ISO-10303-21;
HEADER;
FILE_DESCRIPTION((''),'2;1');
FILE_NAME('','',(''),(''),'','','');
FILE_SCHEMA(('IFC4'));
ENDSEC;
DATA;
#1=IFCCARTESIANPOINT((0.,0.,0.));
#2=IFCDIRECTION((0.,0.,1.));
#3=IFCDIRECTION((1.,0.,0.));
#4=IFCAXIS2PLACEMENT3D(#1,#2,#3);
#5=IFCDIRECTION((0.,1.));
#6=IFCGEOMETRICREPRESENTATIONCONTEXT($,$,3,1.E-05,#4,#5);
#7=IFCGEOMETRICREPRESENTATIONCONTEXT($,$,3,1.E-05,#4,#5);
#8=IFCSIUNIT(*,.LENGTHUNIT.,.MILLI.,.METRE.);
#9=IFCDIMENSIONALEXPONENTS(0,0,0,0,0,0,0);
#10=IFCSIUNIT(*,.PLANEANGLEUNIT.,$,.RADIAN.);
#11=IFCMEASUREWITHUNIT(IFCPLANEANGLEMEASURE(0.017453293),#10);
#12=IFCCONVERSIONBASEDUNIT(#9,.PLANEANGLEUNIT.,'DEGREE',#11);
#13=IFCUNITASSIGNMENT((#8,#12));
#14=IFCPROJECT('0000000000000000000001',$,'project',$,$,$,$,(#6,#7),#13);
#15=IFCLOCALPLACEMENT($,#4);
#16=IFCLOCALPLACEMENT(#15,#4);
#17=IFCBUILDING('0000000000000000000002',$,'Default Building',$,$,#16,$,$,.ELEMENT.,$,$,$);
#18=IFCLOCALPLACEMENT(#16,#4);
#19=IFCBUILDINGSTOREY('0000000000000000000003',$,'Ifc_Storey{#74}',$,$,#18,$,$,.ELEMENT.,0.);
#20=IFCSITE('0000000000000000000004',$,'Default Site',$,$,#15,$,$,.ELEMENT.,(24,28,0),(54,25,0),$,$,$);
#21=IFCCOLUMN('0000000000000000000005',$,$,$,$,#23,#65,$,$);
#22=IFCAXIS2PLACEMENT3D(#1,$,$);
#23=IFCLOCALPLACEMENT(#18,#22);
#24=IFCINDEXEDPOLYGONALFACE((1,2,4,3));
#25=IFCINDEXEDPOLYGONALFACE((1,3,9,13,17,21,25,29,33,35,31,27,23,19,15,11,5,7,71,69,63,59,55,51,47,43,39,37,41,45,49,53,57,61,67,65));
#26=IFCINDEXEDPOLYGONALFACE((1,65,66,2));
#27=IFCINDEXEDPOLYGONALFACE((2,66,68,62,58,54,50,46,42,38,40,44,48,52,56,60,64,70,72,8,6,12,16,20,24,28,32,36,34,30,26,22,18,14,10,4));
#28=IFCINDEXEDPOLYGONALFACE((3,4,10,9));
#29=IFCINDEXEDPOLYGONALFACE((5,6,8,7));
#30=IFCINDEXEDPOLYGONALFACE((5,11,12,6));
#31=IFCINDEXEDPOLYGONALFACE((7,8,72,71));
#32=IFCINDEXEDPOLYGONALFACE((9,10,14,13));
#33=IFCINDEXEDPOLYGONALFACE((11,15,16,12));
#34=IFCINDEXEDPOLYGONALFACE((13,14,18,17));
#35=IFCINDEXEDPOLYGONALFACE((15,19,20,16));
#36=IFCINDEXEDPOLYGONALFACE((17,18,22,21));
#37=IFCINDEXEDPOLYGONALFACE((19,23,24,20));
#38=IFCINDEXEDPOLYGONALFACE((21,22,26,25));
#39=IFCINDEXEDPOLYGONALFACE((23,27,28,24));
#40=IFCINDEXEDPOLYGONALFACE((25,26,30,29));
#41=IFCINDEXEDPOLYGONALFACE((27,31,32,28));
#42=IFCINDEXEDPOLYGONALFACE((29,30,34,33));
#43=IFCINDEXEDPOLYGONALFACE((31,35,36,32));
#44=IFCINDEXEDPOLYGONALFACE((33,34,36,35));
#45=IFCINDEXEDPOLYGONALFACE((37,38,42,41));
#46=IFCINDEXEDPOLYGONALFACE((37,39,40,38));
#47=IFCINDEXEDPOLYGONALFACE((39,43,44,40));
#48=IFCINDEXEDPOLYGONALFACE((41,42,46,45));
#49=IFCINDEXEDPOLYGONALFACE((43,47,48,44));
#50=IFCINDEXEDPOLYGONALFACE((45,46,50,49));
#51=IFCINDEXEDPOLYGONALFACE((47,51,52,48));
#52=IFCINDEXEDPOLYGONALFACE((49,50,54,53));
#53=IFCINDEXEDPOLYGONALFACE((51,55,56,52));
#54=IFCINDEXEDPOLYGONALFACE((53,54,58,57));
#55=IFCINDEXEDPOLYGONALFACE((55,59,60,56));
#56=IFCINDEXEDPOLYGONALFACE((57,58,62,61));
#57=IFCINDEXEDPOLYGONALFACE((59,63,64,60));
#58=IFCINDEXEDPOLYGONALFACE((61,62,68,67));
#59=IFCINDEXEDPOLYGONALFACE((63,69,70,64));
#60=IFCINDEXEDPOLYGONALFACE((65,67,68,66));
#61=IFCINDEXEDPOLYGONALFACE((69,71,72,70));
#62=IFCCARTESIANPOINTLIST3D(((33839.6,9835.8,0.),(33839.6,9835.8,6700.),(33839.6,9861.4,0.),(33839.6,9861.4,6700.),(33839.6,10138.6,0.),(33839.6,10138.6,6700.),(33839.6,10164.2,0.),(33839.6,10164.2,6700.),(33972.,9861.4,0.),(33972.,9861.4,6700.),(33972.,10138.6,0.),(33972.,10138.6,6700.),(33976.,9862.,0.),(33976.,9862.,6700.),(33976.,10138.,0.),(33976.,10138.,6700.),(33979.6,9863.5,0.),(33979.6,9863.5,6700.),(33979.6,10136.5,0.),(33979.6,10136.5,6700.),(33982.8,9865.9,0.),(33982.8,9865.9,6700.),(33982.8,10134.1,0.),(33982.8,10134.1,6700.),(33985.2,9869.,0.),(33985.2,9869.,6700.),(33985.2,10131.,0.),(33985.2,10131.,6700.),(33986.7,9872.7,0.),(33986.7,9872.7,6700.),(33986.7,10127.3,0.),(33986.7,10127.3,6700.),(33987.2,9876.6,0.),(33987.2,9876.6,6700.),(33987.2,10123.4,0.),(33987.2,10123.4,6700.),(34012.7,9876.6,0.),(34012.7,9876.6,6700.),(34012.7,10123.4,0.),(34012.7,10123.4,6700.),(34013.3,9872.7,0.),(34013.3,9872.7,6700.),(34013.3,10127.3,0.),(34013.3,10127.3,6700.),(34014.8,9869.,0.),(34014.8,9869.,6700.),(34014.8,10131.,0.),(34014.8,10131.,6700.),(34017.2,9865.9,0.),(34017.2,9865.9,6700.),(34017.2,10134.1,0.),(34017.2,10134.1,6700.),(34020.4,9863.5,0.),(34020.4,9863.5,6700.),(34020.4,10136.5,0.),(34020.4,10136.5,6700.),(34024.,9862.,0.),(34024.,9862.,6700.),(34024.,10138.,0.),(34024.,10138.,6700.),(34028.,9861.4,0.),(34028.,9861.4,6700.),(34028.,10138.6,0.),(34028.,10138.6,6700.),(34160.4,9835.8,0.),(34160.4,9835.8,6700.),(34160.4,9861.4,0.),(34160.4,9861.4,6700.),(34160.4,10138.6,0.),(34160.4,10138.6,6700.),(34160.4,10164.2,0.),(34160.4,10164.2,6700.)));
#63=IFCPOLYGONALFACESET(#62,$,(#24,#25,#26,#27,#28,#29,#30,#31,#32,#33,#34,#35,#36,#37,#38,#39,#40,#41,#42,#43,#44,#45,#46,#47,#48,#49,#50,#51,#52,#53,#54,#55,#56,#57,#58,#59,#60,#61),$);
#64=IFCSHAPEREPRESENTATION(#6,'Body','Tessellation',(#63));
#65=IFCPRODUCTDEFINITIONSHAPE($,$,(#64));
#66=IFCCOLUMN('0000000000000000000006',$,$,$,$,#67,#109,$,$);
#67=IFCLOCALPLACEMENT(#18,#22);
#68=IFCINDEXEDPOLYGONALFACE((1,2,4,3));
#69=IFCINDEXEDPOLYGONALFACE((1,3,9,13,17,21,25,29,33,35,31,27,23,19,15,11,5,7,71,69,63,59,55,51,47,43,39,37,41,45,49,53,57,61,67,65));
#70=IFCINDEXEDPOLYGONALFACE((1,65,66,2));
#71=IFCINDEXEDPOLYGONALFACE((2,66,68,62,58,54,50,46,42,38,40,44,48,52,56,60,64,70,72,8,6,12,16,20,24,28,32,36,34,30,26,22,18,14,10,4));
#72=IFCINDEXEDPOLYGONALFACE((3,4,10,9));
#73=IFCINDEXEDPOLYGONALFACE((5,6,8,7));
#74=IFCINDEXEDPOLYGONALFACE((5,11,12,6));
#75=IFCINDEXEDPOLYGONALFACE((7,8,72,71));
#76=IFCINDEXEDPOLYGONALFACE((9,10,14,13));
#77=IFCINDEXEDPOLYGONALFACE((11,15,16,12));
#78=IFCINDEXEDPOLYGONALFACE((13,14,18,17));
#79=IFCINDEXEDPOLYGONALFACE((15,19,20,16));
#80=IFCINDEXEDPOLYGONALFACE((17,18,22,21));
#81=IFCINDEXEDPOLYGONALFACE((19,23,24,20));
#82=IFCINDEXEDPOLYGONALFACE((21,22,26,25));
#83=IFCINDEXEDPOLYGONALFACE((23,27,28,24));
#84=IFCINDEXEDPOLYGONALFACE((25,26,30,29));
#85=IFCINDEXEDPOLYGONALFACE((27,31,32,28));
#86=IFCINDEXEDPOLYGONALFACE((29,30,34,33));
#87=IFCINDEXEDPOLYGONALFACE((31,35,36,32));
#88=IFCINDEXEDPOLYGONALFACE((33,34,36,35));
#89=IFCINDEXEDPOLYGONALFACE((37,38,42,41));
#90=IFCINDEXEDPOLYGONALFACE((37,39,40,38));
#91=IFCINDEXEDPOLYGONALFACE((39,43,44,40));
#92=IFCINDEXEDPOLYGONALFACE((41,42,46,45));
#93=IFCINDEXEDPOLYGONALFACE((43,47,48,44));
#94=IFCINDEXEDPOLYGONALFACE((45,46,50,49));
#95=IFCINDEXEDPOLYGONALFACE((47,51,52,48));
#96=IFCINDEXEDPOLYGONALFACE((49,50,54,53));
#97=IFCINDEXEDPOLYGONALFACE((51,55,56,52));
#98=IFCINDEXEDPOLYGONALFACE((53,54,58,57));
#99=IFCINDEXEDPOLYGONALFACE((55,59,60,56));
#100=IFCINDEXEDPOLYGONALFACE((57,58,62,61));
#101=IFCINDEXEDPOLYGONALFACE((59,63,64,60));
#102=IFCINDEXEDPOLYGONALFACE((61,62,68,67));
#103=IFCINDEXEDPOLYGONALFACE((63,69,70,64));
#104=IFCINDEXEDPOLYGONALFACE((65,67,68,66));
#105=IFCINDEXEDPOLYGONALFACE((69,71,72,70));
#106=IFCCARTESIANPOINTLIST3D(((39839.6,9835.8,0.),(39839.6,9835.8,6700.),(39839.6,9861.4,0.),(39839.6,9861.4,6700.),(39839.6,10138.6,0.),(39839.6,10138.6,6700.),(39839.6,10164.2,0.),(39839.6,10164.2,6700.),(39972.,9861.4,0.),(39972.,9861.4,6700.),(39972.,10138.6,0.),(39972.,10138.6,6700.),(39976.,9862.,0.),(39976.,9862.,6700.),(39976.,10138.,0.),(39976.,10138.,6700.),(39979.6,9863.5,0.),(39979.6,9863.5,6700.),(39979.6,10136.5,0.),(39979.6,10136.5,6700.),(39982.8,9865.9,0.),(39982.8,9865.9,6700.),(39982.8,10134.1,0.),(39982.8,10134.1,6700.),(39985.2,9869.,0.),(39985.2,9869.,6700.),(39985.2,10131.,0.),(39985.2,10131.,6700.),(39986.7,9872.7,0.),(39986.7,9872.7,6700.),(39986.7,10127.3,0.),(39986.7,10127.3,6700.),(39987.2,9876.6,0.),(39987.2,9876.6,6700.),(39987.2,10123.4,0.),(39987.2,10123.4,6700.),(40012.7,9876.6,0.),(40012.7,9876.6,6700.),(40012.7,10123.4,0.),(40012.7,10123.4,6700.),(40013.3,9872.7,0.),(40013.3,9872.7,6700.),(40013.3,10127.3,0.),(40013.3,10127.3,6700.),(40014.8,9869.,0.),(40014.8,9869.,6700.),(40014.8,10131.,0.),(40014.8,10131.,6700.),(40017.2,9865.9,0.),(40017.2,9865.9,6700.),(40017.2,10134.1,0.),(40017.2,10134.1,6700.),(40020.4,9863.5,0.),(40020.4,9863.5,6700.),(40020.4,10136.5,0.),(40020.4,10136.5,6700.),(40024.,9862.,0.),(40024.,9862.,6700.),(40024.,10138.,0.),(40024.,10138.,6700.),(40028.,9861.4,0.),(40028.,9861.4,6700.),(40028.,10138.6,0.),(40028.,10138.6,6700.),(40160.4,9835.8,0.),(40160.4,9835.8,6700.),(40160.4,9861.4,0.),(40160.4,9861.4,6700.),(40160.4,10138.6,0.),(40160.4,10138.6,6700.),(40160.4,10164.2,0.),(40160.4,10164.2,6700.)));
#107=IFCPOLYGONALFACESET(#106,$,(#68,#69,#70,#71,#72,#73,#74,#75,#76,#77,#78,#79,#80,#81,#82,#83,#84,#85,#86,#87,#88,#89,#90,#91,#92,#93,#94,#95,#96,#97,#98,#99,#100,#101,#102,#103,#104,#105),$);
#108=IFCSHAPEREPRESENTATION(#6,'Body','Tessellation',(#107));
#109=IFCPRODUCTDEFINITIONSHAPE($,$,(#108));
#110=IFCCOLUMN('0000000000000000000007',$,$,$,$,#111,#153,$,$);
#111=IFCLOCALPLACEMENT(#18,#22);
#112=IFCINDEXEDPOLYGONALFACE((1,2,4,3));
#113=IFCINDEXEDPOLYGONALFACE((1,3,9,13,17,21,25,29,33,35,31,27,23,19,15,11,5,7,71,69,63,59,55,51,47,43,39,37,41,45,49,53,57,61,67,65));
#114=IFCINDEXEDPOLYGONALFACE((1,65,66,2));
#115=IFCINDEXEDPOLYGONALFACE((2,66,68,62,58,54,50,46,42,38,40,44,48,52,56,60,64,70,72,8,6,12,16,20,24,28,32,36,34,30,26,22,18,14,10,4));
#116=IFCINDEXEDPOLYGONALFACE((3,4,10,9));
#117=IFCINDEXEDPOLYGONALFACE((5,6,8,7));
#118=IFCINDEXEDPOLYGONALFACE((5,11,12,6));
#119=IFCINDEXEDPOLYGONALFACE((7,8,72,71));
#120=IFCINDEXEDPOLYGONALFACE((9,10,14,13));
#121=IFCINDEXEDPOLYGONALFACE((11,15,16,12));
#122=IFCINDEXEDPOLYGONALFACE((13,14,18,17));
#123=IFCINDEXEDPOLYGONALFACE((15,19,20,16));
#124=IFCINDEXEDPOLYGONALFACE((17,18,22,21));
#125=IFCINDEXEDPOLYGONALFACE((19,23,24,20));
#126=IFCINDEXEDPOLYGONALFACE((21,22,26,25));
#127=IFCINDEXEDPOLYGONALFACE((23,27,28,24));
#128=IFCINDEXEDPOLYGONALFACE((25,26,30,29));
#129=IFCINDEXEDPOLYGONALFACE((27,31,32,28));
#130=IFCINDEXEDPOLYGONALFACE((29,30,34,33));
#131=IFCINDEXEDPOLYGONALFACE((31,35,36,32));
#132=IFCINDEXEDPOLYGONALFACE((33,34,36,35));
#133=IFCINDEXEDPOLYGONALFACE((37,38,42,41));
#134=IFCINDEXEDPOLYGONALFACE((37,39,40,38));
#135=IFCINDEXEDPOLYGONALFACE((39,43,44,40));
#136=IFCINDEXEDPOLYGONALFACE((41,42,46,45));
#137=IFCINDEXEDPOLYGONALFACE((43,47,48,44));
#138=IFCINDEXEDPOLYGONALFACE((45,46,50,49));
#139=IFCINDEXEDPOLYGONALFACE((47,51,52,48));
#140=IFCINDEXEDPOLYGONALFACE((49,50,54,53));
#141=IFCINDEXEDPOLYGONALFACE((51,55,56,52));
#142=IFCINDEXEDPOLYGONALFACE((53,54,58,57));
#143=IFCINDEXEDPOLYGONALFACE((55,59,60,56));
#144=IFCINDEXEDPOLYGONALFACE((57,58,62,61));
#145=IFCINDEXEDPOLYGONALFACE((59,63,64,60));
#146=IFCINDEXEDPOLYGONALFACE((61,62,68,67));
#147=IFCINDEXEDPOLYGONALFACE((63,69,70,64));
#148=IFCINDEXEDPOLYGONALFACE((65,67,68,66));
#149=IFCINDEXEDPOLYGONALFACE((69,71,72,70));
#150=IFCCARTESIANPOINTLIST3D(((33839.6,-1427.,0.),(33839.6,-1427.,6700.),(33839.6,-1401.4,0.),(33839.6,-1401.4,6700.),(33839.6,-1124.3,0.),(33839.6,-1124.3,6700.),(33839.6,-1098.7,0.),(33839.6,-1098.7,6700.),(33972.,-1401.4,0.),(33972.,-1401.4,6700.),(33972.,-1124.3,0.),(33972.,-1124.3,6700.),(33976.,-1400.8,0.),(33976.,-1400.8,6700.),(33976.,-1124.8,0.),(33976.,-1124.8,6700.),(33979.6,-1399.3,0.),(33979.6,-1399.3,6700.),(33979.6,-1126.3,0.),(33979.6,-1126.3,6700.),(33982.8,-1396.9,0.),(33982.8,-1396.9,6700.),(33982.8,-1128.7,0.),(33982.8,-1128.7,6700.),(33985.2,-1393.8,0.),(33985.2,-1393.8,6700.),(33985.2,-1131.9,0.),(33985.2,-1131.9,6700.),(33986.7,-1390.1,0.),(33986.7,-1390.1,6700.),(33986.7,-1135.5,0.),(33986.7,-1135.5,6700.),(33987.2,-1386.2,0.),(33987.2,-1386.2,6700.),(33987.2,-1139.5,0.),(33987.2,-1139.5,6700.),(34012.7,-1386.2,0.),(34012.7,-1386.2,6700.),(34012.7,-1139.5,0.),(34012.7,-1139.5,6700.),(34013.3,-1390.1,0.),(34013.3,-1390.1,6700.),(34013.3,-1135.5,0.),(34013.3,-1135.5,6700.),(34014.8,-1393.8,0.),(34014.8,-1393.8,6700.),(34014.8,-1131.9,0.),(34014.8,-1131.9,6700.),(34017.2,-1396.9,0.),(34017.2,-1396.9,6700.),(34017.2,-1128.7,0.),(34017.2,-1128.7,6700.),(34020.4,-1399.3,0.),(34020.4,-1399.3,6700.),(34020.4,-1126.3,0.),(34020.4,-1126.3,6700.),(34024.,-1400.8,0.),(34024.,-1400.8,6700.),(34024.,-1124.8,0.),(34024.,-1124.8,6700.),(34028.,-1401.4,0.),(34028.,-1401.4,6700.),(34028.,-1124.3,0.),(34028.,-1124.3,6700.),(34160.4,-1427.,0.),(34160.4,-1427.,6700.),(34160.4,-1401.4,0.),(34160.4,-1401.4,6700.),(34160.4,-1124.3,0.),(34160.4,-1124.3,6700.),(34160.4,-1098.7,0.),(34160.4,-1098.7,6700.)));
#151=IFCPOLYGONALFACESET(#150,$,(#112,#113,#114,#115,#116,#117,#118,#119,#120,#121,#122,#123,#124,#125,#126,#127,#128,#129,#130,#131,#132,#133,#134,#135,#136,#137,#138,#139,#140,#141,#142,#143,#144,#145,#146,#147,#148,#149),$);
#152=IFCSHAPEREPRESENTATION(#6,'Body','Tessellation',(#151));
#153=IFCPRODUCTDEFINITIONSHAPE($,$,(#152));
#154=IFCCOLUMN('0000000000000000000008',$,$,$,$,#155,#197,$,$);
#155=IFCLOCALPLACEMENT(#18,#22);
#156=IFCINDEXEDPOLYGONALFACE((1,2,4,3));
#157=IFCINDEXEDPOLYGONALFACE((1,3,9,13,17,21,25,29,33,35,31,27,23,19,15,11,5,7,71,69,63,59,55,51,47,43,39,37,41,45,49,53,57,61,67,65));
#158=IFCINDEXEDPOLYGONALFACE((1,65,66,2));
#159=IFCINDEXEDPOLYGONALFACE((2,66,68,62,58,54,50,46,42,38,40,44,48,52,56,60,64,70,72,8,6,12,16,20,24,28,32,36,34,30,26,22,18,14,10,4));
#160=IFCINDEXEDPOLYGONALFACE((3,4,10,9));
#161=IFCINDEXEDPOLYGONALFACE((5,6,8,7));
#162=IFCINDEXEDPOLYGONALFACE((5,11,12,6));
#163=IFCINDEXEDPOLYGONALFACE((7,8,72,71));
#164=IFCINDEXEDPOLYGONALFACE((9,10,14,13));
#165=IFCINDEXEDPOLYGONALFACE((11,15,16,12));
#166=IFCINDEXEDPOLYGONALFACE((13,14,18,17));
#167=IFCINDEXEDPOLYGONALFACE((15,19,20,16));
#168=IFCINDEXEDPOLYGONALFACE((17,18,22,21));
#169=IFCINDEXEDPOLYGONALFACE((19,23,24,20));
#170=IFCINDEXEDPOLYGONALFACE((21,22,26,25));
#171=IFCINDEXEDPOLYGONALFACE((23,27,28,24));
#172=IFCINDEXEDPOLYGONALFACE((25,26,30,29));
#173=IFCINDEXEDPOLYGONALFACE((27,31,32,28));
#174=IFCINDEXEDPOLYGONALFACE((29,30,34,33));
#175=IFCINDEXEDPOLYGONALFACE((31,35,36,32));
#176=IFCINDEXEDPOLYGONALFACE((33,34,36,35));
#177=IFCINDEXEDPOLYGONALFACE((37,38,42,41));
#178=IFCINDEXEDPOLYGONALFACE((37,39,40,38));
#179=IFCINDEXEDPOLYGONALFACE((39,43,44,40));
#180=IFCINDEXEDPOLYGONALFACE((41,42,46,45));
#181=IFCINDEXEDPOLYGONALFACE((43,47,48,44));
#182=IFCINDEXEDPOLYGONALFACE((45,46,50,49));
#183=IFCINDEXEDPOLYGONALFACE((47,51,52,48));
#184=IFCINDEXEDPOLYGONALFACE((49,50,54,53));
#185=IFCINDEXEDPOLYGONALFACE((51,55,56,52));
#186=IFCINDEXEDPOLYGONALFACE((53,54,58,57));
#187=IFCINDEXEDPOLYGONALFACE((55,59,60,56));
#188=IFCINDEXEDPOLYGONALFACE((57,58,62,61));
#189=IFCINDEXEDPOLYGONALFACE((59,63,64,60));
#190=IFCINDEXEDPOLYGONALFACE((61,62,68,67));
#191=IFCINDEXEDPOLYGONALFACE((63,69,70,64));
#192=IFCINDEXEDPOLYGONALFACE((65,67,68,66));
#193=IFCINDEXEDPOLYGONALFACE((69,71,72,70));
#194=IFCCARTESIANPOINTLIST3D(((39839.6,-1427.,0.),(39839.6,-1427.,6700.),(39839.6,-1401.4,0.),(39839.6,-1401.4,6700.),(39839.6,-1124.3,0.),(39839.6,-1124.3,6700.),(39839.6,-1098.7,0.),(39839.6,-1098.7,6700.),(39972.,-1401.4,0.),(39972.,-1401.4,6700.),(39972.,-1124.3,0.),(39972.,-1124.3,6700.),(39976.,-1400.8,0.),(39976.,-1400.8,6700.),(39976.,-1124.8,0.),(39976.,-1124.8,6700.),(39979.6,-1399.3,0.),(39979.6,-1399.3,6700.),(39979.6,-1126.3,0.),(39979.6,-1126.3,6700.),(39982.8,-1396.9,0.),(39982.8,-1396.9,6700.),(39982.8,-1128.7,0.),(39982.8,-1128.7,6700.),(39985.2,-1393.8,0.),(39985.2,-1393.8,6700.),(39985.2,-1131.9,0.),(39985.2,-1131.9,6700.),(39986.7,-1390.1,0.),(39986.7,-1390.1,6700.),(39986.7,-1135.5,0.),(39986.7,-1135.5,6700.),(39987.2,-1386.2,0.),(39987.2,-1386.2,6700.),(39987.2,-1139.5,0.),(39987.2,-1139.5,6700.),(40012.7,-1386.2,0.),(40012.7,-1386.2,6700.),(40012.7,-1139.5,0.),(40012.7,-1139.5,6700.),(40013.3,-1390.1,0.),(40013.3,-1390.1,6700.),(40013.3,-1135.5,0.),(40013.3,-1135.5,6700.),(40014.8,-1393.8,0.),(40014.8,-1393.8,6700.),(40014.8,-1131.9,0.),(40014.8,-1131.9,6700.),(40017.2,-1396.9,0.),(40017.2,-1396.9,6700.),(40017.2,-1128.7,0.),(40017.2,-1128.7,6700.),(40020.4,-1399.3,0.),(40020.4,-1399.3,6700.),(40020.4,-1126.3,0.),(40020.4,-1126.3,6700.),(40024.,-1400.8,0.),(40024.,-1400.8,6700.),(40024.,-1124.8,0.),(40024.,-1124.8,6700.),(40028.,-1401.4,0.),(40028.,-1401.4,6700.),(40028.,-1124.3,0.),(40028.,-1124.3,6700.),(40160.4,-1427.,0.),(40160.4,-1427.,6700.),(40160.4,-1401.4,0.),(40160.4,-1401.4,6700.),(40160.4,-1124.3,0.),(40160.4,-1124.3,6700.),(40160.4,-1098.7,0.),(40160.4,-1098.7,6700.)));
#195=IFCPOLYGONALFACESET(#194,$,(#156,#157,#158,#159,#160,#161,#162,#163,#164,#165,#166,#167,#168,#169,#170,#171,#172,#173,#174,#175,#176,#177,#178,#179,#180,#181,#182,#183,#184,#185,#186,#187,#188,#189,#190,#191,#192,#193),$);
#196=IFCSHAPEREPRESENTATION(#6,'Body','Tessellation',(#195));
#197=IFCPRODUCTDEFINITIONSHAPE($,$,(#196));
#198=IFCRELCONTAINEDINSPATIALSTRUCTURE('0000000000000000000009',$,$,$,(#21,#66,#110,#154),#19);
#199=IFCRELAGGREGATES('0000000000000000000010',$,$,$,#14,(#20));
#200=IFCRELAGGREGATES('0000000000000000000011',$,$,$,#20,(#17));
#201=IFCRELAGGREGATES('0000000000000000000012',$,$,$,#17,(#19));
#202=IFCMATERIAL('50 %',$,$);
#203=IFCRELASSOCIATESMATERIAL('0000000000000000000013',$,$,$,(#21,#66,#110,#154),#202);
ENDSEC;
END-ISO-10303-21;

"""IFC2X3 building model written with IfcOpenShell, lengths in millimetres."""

from ifc_helpers import new_model, entity, si_unit, converted_unit, direction, frame, origin_with_axes, origin_2d_with_axis, place, context, project, spatial, i_section, extrude, material, element, save


model = new_model("IFC2X3")

# Units and contexts
context_of_model_1 = context(None, 3, precision=1e-05, world=origin_with_axes(), true_north=direction((0.0, 1.0)))
context_of_model_2 = context(None, 3, precision=1e-05, world=origin_with_axes(), true_north=direction((0.0, 1.0)))
ifc_project = project(units=[si_unit("LENGTHUNIT", "METRE", prefix="MILLI"), converted_unit("PLANEANGLEUNIT", "DEGREE", entity("IfcPlaneAngleMeasure", 0.017453293), si_unit("PLANEANGLEUNIT", "RADIAN"), dimensions=[0, 0, 0, 0, 0, 0, 0])], contexts=[context_of_model_1, context_of_model_2])

# Site, building, storey
site_placement = place(None, origin_with_axes())
site = spatial("IfcSite", under=ifc_project, at=site_placement, Name="Default Site", CompositionType="ELEMENT", RefLatitude=(24, 28, 0), RefLongitude=(54, 25, 0))
building_placement = place(site_placement, origin_with_axes())
building = spatial("IfcBuilding", under=site, at=building_placement, Name="Default Building", CompositionType="ELEMENT")
storey_placement = place(building_placement, origin_with_axes())
storey = spatial("IfcBuildingStorey", under=building, at=storey_placement, Name="Ifc_Storey{#74}", CompositionType="ELEMENT", Elevation=0.0)

# Columns
ifc_material_1 = material(Name="50 %")
for number, where, z_axis, x_axis in (
    (1, (34000.0, 10000.0, 0.0), (0.0, 0.0, 1.0), (1.0, 0.0, 0.0)),
    (2, (40000.0, 10000.0, 0.0), (0.0, 0.0, 1.0), (1.0, 0.0, 0.0)),
):
    element("IfcColumn", number, at=place(storey_placement, frame(where, z_axis=z_axis, x_axis=x_axis)), inside=storey, material=ifc_material_1, context=context_of_model_1, shape_type="SweptSolid", body=[
        extrude(i_section(OverallWidth=320.9, OverallDepth=328.3, WebThickness=25.5, FlangeThickness=25.6, FilletRadius=15.2, at=origin_2d_with_axis()), origin_with_axes(), (0.0, 0.0, 1.0), 6700.0),
    ])
for number, where, z_axis, x_axis in (
    (3, (34000.0, -1262.8, 0.0), (0.0, 0.0, 1.0), (-1.0, 0.0, 0.0)),
    (4, (40000.0, -1262.8, 0.0), (0.0, 0.0, 1.0), (-1.0, 0.0, 0.0)),
):
    element("IfcColumn", number, at=place(storey_placement, frame(where, z_axis=z_axis, x_axis=x_axis)), inside=storey, material=ifc_material_1, context=context_of_model_1, shape_type="SweptSolid", body=[
        extrude(i_section(OverallWidth=320.9, OverallDepth=328.3, WebThickness=25.5, FlangeThickness=25.6, FilletRadius=15.2, at=origin_2d_with_axis()), frame((0.0, 0.0, 0.0), z_axis=(0.0, 0.0, 1.0), x_axis=(-1.0, 0.0, 0.0)), (0.0, 0.0, 1.0), 6700.0),
    ])

save(model, "model.ifc")
